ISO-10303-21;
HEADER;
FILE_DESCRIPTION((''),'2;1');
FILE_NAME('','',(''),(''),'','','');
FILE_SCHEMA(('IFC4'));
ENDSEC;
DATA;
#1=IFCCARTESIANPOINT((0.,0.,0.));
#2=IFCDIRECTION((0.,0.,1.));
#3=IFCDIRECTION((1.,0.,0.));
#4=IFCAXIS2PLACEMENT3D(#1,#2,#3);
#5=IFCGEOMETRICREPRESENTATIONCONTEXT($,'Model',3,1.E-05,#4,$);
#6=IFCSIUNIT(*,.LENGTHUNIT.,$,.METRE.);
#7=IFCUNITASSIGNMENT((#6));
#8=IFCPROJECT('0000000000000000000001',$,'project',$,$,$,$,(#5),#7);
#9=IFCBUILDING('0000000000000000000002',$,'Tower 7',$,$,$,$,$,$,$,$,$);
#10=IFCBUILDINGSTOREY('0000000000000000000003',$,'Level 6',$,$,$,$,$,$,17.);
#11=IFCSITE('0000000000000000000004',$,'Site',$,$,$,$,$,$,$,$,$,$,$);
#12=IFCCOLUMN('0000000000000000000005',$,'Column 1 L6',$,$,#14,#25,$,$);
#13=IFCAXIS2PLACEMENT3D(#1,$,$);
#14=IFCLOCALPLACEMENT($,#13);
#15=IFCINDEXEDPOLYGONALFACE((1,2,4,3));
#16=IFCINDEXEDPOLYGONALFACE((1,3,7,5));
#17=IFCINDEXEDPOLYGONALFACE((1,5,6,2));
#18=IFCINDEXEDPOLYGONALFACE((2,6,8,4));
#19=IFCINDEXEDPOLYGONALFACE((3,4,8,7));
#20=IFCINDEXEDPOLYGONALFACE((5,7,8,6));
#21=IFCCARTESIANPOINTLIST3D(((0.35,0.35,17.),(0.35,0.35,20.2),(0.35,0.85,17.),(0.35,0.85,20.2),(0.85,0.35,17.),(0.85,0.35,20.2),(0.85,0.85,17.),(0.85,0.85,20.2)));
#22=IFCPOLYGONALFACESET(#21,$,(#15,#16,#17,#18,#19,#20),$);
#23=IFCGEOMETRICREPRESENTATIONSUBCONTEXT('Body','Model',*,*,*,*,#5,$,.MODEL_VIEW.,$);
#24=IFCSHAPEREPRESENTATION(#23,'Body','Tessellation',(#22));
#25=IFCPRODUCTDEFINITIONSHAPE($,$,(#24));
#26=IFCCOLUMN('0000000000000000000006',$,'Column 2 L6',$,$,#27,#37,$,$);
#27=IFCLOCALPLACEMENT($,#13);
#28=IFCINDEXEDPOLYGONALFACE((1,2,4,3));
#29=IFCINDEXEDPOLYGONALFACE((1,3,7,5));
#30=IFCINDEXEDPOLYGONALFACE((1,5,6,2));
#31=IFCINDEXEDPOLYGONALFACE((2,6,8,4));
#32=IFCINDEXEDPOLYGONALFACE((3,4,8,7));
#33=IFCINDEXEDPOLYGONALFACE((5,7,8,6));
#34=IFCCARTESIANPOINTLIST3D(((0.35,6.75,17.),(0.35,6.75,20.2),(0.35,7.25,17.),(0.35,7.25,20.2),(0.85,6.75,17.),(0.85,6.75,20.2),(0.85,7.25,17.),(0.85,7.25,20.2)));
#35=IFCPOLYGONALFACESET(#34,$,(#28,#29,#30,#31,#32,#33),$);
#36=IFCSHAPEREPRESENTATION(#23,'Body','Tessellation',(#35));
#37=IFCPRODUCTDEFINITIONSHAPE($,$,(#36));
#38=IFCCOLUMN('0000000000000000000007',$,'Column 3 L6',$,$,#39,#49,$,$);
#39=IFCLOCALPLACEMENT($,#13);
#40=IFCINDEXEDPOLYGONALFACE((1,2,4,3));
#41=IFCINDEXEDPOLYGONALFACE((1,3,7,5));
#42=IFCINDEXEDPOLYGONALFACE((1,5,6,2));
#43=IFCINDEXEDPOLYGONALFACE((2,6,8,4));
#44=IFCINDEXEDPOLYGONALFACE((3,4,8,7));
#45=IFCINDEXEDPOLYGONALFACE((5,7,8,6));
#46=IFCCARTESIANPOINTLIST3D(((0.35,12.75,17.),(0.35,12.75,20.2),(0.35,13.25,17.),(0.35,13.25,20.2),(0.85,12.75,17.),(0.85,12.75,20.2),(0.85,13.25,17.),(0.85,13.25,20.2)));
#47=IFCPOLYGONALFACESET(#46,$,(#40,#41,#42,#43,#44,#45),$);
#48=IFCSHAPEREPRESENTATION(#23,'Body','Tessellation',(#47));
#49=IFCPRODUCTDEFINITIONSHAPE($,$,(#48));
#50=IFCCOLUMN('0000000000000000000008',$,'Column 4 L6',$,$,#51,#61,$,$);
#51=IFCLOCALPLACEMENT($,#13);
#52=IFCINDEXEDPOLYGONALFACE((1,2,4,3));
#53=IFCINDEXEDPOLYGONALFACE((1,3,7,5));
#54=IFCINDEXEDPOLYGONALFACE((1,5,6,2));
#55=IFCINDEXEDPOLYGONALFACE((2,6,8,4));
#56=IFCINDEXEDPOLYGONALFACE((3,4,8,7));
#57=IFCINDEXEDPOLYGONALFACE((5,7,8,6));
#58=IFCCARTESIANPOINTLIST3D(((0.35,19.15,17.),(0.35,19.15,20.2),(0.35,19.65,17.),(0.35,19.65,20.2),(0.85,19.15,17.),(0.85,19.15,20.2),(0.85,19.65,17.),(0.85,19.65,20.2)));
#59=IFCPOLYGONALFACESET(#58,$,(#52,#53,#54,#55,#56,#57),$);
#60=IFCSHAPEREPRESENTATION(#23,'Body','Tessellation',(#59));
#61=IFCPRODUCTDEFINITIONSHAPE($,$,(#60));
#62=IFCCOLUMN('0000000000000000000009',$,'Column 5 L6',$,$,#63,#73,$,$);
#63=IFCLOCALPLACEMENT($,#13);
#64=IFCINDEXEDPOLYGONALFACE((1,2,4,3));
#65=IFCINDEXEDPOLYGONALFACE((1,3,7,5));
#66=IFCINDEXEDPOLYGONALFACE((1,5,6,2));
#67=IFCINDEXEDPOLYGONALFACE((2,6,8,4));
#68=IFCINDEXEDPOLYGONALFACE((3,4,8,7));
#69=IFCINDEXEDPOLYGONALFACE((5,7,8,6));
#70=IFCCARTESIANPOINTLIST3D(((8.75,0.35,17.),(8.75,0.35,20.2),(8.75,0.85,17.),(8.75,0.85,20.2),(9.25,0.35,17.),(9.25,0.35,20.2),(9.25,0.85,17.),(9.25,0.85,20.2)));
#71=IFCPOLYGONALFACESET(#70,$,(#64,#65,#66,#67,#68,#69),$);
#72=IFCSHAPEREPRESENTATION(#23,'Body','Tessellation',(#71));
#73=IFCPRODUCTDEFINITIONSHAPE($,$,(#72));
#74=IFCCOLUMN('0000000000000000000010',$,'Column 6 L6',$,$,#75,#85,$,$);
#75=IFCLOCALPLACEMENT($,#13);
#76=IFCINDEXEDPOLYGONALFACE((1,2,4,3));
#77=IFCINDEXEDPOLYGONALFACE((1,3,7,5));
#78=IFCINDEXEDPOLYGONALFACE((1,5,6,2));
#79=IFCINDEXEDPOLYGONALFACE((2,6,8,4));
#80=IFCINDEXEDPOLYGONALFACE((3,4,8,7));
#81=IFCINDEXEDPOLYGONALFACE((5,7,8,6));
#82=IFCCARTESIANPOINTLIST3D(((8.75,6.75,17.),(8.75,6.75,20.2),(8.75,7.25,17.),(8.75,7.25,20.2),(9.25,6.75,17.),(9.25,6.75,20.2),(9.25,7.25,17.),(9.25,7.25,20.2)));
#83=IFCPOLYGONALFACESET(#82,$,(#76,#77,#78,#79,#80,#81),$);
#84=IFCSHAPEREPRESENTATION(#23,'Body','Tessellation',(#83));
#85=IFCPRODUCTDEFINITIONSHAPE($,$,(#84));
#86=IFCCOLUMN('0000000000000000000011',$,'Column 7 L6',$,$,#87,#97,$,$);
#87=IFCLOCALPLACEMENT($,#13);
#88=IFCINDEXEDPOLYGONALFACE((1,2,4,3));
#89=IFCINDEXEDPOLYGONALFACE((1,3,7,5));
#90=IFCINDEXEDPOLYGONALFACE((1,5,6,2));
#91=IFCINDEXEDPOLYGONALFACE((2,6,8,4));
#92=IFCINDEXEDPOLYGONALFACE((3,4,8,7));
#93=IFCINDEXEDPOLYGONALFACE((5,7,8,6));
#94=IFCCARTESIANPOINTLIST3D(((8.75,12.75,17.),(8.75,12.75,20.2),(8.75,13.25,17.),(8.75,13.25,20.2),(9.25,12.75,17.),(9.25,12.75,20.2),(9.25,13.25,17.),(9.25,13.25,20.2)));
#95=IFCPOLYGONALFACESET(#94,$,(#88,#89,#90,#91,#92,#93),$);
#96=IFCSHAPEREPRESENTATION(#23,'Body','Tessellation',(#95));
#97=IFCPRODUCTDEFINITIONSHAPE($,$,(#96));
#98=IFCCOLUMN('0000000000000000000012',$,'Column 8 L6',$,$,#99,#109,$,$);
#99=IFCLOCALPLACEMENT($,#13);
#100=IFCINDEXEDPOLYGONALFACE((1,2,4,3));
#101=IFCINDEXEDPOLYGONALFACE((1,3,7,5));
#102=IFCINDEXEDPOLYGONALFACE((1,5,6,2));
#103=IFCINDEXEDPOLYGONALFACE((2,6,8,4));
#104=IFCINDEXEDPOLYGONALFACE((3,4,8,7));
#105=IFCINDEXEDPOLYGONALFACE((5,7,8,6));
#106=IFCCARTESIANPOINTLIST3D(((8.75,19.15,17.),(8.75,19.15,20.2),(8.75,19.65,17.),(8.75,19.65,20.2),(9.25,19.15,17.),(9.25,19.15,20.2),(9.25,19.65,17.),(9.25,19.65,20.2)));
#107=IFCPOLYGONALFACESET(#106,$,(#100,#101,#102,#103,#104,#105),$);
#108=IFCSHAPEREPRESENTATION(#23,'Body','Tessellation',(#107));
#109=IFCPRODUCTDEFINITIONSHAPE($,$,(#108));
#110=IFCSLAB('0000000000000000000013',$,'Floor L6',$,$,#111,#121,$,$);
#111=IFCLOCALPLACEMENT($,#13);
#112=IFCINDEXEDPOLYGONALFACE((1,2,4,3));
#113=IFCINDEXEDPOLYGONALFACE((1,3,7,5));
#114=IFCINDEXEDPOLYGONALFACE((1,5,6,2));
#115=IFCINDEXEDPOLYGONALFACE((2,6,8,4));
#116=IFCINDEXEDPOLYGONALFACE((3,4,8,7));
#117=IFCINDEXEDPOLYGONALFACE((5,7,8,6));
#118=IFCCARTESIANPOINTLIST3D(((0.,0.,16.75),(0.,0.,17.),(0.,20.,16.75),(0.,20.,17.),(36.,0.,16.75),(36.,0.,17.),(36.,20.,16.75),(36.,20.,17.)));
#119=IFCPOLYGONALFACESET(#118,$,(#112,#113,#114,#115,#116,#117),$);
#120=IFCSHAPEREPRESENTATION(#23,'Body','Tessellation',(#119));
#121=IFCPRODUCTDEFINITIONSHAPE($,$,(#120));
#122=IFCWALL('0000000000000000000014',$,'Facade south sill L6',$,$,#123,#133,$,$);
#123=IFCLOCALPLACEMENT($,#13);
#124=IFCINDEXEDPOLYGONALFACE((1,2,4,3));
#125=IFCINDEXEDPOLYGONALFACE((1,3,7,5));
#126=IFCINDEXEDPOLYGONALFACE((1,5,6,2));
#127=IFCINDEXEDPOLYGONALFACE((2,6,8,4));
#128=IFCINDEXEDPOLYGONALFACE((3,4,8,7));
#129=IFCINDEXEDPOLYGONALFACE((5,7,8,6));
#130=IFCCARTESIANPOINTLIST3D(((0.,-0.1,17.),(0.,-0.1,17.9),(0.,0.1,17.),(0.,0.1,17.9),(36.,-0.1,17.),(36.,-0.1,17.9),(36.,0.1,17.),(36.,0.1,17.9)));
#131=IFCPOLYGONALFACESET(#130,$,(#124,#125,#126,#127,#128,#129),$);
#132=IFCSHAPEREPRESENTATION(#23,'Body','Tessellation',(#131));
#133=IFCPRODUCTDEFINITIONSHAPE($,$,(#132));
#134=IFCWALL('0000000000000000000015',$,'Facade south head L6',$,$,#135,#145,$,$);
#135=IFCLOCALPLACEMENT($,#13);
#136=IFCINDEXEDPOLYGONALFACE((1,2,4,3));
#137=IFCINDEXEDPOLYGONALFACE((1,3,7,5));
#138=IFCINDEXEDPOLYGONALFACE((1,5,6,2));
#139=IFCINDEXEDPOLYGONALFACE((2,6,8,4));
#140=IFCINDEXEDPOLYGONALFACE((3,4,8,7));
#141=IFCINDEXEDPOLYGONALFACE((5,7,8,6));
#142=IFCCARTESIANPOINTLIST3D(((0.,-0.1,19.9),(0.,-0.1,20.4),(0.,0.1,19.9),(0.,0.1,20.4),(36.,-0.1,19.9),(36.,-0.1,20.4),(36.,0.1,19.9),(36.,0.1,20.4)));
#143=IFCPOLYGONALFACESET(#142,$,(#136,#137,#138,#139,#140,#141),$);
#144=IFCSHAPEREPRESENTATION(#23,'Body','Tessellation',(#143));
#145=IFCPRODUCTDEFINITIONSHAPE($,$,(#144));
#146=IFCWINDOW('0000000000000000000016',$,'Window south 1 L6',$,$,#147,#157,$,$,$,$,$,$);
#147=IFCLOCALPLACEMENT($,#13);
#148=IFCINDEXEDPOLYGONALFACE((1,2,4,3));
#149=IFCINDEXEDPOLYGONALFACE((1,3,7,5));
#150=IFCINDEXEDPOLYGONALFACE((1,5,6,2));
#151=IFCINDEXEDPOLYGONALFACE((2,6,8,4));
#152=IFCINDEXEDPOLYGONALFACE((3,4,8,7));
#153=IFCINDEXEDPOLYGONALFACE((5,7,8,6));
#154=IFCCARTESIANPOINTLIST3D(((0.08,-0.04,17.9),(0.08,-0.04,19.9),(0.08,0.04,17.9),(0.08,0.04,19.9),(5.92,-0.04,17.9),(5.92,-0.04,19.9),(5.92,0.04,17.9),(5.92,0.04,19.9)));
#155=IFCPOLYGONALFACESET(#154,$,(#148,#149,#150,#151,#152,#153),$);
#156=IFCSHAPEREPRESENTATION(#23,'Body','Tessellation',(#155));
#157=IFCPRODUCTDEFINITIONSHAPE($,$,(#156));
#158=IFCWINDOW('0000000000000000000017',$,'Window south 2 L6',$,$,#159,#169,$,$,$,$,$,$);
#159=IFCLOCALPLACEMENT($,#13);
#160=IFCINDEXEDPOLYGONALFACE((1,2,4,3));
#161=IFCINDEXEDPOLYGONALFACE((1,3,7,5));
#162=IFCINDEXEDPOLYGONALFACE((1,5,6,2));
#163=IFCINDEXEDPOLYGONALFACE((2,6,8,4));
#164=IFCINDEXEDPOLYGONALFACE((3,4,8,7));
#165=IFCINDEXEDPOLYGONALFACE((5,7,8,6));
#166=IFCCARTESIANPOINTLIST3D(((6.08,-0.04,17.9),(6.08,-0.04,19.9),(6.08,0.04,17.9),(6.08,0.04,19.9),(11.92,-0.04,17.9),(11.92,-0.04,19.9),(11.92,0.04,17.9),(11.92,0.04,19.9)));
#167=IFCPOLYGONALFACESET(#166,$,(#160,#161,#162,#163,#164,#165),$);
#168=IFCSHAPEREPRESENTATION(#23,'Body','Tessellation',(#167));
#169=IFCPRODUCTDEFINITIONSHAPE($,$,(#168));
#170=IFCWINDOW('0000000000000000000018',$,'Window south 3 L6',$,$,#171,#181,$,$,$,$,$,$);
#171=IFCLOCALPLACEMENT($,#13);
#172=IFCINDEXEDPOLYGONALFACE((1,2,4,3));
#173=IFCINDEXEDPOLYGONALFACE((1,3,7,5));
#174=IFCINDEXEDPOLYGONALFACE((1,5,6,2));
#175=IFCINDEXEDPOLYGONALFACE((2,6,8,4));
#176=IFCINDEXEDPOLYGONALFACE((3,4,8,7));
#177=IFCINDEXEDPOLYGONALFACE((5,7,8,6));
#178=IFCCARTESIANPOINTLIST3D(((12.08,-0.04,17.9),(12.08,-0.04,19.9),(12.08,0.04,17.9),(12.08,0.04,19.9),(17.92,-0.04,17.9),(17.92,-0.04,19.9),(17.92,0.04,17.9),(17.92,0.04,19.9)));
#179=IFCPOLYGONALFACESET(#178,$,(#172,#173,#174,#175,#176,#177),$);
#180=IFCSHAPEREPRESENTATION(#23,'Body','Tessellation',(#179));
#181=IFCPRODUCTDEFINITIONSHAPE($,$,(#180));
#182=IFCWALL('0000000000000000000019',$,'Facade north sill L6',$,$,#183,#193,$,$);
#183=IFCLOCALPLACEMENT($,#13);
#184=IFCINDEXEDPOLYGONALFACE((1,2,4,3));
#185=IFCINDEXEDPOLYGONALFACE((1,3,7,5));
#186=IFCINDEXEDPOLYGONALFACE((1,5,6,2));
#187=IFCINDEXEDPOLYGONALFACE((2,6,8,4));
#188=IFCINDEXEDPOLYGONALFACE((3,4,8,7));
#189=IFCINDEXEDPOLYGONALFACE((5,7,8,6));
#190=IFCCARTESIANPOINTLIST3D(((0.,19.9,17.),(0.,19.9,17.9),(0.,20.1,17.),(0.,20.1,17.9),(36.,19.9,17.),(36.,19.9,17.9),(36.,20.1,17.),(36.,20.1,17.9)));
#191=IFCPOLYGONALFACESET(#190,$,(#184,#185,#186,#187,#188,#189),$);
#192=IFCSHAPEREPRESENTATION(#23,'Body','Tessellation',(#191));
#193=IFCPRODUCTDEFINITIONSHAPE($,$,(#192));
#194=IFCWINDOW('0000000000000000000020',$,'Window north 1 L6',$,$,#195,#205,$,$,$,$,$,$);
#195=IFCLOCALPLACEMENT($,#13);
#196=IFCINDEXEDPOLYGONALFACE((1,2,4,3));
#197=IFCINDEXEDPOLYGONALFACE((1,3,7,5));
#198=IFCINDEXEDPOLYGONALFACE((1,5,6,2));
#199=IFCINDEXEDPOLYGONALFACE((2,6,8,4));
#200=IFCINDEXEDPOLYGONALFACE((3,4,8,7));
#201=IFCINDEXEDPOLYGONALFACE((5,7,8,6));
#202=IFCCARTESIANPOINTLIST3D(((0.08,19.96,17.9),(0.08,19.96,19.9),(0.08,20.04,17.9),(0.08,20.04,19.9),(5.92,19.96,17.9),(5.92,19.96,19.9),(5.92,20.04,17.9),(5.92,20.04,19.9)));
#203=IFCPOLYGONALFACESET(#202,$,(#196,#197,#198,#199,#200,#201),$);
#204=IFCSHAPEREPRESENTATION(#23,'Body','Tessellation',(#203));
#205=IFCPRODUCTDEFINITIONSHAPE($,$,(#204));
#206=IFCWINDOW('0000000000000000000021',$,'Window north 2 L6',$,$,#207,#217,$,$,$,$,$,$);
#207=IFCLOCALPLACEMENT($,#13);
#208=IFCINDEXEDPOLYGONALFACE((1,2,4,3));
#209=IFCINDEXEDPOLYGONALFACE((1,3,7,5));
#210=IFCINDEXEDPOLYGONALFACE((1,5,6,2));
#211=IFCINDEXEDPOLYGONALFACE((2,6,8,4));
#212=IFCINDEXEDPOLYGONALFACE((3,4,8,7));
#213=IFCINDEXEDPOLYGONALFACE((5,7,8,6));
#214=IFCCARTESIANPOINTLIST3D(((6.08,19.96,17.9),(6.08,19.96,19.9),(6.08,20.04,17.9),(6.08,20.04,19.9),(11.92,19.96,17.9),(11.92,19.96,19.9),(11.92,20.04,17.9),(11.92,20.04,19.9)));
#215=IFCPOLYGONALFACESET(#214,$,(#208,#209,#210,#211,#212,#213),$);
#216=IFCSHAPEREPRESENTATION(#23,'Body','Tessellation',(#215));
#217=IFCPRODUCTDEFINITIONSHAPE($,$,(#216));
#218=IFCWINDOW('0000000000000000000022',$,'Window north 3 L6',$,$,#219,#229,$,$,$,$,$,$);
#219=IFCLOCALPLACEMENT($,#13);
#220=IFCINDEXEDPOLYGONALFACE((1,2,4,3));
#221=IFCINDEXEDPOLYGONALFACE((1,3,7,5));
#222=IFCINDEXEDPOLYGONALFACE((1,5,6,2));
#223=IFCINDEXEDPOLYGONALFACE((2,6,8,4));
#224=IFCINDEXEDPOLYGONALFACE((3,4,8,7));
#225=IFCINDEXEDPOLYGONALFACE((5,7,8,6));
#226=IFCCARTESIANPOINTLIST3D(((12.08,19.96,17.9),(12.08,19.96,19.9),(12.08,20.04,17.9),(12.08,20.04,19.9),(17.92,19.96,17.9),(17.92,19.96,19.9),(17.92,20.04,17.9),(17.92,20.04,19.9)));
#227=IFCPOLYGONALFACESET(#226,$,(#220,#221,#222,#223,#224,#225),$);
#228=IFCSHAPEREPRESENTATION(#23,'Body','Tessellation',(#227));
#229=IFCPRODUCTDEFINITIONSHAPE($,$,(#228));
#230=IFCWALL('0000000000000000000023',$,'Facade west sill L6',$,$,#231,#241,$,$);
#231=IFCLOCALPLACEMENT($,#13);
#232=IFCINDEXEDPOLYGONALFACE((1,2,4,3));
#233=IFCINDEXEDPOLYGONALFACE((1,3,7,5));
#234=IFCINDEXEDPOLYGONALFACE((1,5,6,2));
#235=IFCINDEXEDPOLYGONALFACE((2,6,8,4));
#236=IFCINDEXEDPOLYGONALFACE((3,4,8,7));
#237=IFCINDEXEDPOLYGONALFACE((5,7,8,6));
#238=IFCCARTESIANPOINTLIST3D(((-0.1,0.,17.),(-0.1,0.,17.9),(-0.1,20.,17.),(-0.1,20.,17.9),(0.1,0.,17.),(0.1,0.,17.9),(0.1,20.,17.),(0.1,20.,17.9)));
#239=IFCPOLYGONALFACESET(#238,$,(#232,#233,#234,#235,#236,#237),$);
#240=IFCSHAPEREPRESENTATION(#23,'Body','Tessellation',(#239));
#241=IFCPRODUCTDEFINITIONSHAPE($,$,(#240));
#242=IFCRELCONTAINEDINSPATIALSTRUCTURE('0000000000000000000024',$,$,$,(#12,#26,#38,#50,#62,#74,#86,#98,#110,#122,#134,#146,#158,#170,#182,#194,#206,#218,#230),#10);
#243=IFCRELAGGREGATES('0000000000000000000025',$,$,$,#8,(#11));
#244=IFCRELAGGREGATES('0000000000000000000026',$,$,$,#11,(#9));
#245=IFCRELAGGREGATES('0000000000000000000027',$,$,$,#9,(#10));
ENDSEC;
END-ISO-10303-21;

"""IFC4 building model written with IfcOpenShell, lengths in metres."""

from ifc_helpers import new_model, si_unit, frame, origin, origin_with_axes, origin_2d, place, context, subcontext, project, spatial, rectangle, extrude, element, save


model = new_model("IFC4")

# Units and contexts
model_context = context("Model", 3, precision=1e-05, world=origin_with_axes())
body_context = subcontext(model_context, "Body", "Model", "MODEL_VIEW")
ifc_project = project(units=[si_unit("LENGTHUNIT", "METRE")], contexts=[model_context])

# Site, building, storey
site = spatial("IfcSite", under=ifc_project, Name="Site")
building = spatial("IfcBuilding", under=site, Name="Tower 7")
storey = spatial("IfcBuildingStorey", under=building, Name="Level 6", Elevation=17.0)

# Columns
for number, where, z_axis, x_axis, name in (
    (1, (0.6, 0.6, 17.0), (0.0, 0.0, 1.0), (1.0, 0.0, 0.0), "Column 1 L6"),
    (2, (0.6, 7.0, 17.0), (0.0, 0.0, 1.0), (1.0, 0.0, 0.0), "Column 2 L6"),
    (3, (0.6, 13.0, 17.0), (0.0, 0.0, 1.0), (1.0, 0.0, 0.0), "Column 3 L6"),
    (4, (0.6, 19.4, 17.0), (0.0, 0.0, 1.0), (1.0, 0.0, 0.0), "Column 4 L6"),
    (5, (9.0, 0.6, 17.0), (0.0, 0.0, 1.0), (1.0, 0.0, 0.0), "Column 5 L6"),
    (6, (9.0, 7.0, 17.0), (0.0, 0.0, 1.0), (1.0, 0.0, 0.0), "Column 6 L6"),
    (7, (9.0, 13.0, 17.0), (0.0, 0.0, 1.0), (1.0, 0.0, 0.0), "Column 7 L6"),
    (8, (9.0, 19.4, 17.0), (0.0, 0.0, 1.0), (1.0, 0.0, 0.0), "Column 8 L6"),
):
    element("IfcColumn", number, at=place(None, frame(where, z_axis=z_axis, x_axis=x_axis)), inside=storey, Name=name, context=body_context, shape_type="SweptSolid", body=[
        extrude(rectangle(XDim=0.5, YDim=0.5, at=origin_2d()), origin(), (0.0, 0.0, 1.0), 3.2),
    ])

# Slab
slab_placement = place(None, frame((18.0, 10.0, 16.75), z_axis=(0.0, 0.0, 1.0), x_axis=(1.0, 0.0, 0.0)))
element("IfcSlab", 9, at=slab_placement, inside=storey, Name="Floor L6", context=body_context, shape_type="SweptSolid", body=[
    extrude(rectangle(XDim=36.0, YDim=20.0, at=origin_2d()), origin(), (0.0, 0.0, 1.0), 0.25),
])

# Walls
wall_1_placement = place(None, frame((18.0, 0.0, 17.0), z_axis=(0.0, 0.0, 1.0), x_axis=(1.0, 0.0, 0.0)))
element("IfcWall", 10, at=wall_1_placement, inside=storey, Name="Facade south sill L6", context=body_context, shape_type="SweptSolid", body=[
    extrude(rectangle(XDim=36.0, YDim=0.2, at=origin_2d()), origin(), (0.0, 0.0, 1.0), 0.9),
])
wall_2_placement = place(None, frame((18.0, 0.0, 19.9), z_axis=(0.0, 0.0, 1.0), x_axis=(1.0, 0.0, 0.0)))
element("IfcWall", 11, at=wall_2_placement, inside=storey, Name="Facade south head L6", context=body_context, shape_type="SweptSolid", body=[
    extrude(rectangle(XDim=36.0, YDim=0.2, at=origin_2d()), origin(), (0.0, 0.0, 1.0), 0.5),
])

# Windows
for number, where, z_axis, x_axis, name in (
    (12, (3.0, 0.0, 17.9), (0.0, 0.0, 1.0), (1.0, 0.0, 0.0), "Window south 1 L6"),
    (13, (9.0, 0.0, 17.9), (0.0, 0.0, 1.0), (1.0, 0.0, 0.0), "Window south 2 L6"),
):
    element("IfcWindow", number, at=place(None, frame(where, z_axis=z_axis, x_axis=x_axis)), inside=storey, Name=name, context=body_context, shape_type="SweptSolid", body=[
        extrude(rectangle(XDim=5.84, YDim=0.08, at=origin_2d()), origin(), (0.0, 0.0, 1.0), 2.0),
    ])
window_1_placement = place(None, frame((15.0, 0.0, 17.9), z_axis=(0.0, 0.0, 1.0), x_axis=(1.0, 0.0, 0.0)))
element("IfcWindow", 14, at=window_1_placement, inside=storey, Name="Window south 3 L6", context=body_context, shape_type="SweptSolid", body=[
    extrude(rectangle(XDim=5.84, YDim=0.08, at=origin_2d()), origin(), (0.0, 0.0, 1.0), 2.0),
])

# Wall
wall_3_placement = place(None, frame((18.0, 20.0, 17.0), z_axis=(0.0, 0.0, 1.0), x_axis=(1.0, 0.0, 0.0)))
element("IfcWall", 15, at=wall_3_placement, inside=storey, Name="Facade north sill L6", context=body_context, shape_type="SweptSolid", body=[
    extrude(rectangle(XDim=36.0, YDim=0.2, at=origin_2d()), origin(), (0.0, 0.0, 1.0), 0.9),
])

# Windows
for number, where, z_axis, x_axis, name in (
    (16, (3.0, 20.0, 17.9), (0.0, 0.0, 1.0), (1.0, 0.0, 0.0), "Window north 1 L6"),
    (17, (9.0, 20.0, 17.9), (0.0, 0.0, 1.0), (1.0, 0.0, 0.0), "Window north 2 L6"),
):
    element("IfcWindow", number, at=place(None, frame(where, z_axis=z_axis, x_axis=x_axis)), inside=storey, Name=name, context=body_context, shape_type="SweptSolid", body=[
        extrude(rectangle(XDim=5.84, YDim=0.08, at=origin_2d()), origin(), (0.0, 0.0, 1.0), 2.0),
    ])
window_2_placement = place(None, frame((15.0, 20.0, 17.9), z_axis=(0.0, 0.0, 1.0), x_axis=(1.0, 0.0, 0.0)))
element("IfcWindow", 18, at=window_2_placement, inside=storey, Name="Window north 3 L6", context=body_context, shape_type="SweptSolid", body=[
    extrude(rectangle(XDim=5.84, YDim=0.08, at=origin_2d()), origin(), (0.0, 0.0, 1.0), 2.0),
])

# Wall
wall_4_placement = place(None, frame((0.0, 10.0, 17.0), z_axis=(0.0, 0.0, 1.0), x_axis=(1.0, 0.0, 0.0)))
element("IfcWall", 19, at=wall_4_placement, inside=storey, Name="Facade west sill L6", context=body_context, shape_type="SweptSolid", body=[
    extrude(rectangle(XDim=0.2, YDim=20.0, at=origin_2d()), origin(), (0.0, 0.0, 1.0), 0.9),
])

save(model, "model.ifc")
